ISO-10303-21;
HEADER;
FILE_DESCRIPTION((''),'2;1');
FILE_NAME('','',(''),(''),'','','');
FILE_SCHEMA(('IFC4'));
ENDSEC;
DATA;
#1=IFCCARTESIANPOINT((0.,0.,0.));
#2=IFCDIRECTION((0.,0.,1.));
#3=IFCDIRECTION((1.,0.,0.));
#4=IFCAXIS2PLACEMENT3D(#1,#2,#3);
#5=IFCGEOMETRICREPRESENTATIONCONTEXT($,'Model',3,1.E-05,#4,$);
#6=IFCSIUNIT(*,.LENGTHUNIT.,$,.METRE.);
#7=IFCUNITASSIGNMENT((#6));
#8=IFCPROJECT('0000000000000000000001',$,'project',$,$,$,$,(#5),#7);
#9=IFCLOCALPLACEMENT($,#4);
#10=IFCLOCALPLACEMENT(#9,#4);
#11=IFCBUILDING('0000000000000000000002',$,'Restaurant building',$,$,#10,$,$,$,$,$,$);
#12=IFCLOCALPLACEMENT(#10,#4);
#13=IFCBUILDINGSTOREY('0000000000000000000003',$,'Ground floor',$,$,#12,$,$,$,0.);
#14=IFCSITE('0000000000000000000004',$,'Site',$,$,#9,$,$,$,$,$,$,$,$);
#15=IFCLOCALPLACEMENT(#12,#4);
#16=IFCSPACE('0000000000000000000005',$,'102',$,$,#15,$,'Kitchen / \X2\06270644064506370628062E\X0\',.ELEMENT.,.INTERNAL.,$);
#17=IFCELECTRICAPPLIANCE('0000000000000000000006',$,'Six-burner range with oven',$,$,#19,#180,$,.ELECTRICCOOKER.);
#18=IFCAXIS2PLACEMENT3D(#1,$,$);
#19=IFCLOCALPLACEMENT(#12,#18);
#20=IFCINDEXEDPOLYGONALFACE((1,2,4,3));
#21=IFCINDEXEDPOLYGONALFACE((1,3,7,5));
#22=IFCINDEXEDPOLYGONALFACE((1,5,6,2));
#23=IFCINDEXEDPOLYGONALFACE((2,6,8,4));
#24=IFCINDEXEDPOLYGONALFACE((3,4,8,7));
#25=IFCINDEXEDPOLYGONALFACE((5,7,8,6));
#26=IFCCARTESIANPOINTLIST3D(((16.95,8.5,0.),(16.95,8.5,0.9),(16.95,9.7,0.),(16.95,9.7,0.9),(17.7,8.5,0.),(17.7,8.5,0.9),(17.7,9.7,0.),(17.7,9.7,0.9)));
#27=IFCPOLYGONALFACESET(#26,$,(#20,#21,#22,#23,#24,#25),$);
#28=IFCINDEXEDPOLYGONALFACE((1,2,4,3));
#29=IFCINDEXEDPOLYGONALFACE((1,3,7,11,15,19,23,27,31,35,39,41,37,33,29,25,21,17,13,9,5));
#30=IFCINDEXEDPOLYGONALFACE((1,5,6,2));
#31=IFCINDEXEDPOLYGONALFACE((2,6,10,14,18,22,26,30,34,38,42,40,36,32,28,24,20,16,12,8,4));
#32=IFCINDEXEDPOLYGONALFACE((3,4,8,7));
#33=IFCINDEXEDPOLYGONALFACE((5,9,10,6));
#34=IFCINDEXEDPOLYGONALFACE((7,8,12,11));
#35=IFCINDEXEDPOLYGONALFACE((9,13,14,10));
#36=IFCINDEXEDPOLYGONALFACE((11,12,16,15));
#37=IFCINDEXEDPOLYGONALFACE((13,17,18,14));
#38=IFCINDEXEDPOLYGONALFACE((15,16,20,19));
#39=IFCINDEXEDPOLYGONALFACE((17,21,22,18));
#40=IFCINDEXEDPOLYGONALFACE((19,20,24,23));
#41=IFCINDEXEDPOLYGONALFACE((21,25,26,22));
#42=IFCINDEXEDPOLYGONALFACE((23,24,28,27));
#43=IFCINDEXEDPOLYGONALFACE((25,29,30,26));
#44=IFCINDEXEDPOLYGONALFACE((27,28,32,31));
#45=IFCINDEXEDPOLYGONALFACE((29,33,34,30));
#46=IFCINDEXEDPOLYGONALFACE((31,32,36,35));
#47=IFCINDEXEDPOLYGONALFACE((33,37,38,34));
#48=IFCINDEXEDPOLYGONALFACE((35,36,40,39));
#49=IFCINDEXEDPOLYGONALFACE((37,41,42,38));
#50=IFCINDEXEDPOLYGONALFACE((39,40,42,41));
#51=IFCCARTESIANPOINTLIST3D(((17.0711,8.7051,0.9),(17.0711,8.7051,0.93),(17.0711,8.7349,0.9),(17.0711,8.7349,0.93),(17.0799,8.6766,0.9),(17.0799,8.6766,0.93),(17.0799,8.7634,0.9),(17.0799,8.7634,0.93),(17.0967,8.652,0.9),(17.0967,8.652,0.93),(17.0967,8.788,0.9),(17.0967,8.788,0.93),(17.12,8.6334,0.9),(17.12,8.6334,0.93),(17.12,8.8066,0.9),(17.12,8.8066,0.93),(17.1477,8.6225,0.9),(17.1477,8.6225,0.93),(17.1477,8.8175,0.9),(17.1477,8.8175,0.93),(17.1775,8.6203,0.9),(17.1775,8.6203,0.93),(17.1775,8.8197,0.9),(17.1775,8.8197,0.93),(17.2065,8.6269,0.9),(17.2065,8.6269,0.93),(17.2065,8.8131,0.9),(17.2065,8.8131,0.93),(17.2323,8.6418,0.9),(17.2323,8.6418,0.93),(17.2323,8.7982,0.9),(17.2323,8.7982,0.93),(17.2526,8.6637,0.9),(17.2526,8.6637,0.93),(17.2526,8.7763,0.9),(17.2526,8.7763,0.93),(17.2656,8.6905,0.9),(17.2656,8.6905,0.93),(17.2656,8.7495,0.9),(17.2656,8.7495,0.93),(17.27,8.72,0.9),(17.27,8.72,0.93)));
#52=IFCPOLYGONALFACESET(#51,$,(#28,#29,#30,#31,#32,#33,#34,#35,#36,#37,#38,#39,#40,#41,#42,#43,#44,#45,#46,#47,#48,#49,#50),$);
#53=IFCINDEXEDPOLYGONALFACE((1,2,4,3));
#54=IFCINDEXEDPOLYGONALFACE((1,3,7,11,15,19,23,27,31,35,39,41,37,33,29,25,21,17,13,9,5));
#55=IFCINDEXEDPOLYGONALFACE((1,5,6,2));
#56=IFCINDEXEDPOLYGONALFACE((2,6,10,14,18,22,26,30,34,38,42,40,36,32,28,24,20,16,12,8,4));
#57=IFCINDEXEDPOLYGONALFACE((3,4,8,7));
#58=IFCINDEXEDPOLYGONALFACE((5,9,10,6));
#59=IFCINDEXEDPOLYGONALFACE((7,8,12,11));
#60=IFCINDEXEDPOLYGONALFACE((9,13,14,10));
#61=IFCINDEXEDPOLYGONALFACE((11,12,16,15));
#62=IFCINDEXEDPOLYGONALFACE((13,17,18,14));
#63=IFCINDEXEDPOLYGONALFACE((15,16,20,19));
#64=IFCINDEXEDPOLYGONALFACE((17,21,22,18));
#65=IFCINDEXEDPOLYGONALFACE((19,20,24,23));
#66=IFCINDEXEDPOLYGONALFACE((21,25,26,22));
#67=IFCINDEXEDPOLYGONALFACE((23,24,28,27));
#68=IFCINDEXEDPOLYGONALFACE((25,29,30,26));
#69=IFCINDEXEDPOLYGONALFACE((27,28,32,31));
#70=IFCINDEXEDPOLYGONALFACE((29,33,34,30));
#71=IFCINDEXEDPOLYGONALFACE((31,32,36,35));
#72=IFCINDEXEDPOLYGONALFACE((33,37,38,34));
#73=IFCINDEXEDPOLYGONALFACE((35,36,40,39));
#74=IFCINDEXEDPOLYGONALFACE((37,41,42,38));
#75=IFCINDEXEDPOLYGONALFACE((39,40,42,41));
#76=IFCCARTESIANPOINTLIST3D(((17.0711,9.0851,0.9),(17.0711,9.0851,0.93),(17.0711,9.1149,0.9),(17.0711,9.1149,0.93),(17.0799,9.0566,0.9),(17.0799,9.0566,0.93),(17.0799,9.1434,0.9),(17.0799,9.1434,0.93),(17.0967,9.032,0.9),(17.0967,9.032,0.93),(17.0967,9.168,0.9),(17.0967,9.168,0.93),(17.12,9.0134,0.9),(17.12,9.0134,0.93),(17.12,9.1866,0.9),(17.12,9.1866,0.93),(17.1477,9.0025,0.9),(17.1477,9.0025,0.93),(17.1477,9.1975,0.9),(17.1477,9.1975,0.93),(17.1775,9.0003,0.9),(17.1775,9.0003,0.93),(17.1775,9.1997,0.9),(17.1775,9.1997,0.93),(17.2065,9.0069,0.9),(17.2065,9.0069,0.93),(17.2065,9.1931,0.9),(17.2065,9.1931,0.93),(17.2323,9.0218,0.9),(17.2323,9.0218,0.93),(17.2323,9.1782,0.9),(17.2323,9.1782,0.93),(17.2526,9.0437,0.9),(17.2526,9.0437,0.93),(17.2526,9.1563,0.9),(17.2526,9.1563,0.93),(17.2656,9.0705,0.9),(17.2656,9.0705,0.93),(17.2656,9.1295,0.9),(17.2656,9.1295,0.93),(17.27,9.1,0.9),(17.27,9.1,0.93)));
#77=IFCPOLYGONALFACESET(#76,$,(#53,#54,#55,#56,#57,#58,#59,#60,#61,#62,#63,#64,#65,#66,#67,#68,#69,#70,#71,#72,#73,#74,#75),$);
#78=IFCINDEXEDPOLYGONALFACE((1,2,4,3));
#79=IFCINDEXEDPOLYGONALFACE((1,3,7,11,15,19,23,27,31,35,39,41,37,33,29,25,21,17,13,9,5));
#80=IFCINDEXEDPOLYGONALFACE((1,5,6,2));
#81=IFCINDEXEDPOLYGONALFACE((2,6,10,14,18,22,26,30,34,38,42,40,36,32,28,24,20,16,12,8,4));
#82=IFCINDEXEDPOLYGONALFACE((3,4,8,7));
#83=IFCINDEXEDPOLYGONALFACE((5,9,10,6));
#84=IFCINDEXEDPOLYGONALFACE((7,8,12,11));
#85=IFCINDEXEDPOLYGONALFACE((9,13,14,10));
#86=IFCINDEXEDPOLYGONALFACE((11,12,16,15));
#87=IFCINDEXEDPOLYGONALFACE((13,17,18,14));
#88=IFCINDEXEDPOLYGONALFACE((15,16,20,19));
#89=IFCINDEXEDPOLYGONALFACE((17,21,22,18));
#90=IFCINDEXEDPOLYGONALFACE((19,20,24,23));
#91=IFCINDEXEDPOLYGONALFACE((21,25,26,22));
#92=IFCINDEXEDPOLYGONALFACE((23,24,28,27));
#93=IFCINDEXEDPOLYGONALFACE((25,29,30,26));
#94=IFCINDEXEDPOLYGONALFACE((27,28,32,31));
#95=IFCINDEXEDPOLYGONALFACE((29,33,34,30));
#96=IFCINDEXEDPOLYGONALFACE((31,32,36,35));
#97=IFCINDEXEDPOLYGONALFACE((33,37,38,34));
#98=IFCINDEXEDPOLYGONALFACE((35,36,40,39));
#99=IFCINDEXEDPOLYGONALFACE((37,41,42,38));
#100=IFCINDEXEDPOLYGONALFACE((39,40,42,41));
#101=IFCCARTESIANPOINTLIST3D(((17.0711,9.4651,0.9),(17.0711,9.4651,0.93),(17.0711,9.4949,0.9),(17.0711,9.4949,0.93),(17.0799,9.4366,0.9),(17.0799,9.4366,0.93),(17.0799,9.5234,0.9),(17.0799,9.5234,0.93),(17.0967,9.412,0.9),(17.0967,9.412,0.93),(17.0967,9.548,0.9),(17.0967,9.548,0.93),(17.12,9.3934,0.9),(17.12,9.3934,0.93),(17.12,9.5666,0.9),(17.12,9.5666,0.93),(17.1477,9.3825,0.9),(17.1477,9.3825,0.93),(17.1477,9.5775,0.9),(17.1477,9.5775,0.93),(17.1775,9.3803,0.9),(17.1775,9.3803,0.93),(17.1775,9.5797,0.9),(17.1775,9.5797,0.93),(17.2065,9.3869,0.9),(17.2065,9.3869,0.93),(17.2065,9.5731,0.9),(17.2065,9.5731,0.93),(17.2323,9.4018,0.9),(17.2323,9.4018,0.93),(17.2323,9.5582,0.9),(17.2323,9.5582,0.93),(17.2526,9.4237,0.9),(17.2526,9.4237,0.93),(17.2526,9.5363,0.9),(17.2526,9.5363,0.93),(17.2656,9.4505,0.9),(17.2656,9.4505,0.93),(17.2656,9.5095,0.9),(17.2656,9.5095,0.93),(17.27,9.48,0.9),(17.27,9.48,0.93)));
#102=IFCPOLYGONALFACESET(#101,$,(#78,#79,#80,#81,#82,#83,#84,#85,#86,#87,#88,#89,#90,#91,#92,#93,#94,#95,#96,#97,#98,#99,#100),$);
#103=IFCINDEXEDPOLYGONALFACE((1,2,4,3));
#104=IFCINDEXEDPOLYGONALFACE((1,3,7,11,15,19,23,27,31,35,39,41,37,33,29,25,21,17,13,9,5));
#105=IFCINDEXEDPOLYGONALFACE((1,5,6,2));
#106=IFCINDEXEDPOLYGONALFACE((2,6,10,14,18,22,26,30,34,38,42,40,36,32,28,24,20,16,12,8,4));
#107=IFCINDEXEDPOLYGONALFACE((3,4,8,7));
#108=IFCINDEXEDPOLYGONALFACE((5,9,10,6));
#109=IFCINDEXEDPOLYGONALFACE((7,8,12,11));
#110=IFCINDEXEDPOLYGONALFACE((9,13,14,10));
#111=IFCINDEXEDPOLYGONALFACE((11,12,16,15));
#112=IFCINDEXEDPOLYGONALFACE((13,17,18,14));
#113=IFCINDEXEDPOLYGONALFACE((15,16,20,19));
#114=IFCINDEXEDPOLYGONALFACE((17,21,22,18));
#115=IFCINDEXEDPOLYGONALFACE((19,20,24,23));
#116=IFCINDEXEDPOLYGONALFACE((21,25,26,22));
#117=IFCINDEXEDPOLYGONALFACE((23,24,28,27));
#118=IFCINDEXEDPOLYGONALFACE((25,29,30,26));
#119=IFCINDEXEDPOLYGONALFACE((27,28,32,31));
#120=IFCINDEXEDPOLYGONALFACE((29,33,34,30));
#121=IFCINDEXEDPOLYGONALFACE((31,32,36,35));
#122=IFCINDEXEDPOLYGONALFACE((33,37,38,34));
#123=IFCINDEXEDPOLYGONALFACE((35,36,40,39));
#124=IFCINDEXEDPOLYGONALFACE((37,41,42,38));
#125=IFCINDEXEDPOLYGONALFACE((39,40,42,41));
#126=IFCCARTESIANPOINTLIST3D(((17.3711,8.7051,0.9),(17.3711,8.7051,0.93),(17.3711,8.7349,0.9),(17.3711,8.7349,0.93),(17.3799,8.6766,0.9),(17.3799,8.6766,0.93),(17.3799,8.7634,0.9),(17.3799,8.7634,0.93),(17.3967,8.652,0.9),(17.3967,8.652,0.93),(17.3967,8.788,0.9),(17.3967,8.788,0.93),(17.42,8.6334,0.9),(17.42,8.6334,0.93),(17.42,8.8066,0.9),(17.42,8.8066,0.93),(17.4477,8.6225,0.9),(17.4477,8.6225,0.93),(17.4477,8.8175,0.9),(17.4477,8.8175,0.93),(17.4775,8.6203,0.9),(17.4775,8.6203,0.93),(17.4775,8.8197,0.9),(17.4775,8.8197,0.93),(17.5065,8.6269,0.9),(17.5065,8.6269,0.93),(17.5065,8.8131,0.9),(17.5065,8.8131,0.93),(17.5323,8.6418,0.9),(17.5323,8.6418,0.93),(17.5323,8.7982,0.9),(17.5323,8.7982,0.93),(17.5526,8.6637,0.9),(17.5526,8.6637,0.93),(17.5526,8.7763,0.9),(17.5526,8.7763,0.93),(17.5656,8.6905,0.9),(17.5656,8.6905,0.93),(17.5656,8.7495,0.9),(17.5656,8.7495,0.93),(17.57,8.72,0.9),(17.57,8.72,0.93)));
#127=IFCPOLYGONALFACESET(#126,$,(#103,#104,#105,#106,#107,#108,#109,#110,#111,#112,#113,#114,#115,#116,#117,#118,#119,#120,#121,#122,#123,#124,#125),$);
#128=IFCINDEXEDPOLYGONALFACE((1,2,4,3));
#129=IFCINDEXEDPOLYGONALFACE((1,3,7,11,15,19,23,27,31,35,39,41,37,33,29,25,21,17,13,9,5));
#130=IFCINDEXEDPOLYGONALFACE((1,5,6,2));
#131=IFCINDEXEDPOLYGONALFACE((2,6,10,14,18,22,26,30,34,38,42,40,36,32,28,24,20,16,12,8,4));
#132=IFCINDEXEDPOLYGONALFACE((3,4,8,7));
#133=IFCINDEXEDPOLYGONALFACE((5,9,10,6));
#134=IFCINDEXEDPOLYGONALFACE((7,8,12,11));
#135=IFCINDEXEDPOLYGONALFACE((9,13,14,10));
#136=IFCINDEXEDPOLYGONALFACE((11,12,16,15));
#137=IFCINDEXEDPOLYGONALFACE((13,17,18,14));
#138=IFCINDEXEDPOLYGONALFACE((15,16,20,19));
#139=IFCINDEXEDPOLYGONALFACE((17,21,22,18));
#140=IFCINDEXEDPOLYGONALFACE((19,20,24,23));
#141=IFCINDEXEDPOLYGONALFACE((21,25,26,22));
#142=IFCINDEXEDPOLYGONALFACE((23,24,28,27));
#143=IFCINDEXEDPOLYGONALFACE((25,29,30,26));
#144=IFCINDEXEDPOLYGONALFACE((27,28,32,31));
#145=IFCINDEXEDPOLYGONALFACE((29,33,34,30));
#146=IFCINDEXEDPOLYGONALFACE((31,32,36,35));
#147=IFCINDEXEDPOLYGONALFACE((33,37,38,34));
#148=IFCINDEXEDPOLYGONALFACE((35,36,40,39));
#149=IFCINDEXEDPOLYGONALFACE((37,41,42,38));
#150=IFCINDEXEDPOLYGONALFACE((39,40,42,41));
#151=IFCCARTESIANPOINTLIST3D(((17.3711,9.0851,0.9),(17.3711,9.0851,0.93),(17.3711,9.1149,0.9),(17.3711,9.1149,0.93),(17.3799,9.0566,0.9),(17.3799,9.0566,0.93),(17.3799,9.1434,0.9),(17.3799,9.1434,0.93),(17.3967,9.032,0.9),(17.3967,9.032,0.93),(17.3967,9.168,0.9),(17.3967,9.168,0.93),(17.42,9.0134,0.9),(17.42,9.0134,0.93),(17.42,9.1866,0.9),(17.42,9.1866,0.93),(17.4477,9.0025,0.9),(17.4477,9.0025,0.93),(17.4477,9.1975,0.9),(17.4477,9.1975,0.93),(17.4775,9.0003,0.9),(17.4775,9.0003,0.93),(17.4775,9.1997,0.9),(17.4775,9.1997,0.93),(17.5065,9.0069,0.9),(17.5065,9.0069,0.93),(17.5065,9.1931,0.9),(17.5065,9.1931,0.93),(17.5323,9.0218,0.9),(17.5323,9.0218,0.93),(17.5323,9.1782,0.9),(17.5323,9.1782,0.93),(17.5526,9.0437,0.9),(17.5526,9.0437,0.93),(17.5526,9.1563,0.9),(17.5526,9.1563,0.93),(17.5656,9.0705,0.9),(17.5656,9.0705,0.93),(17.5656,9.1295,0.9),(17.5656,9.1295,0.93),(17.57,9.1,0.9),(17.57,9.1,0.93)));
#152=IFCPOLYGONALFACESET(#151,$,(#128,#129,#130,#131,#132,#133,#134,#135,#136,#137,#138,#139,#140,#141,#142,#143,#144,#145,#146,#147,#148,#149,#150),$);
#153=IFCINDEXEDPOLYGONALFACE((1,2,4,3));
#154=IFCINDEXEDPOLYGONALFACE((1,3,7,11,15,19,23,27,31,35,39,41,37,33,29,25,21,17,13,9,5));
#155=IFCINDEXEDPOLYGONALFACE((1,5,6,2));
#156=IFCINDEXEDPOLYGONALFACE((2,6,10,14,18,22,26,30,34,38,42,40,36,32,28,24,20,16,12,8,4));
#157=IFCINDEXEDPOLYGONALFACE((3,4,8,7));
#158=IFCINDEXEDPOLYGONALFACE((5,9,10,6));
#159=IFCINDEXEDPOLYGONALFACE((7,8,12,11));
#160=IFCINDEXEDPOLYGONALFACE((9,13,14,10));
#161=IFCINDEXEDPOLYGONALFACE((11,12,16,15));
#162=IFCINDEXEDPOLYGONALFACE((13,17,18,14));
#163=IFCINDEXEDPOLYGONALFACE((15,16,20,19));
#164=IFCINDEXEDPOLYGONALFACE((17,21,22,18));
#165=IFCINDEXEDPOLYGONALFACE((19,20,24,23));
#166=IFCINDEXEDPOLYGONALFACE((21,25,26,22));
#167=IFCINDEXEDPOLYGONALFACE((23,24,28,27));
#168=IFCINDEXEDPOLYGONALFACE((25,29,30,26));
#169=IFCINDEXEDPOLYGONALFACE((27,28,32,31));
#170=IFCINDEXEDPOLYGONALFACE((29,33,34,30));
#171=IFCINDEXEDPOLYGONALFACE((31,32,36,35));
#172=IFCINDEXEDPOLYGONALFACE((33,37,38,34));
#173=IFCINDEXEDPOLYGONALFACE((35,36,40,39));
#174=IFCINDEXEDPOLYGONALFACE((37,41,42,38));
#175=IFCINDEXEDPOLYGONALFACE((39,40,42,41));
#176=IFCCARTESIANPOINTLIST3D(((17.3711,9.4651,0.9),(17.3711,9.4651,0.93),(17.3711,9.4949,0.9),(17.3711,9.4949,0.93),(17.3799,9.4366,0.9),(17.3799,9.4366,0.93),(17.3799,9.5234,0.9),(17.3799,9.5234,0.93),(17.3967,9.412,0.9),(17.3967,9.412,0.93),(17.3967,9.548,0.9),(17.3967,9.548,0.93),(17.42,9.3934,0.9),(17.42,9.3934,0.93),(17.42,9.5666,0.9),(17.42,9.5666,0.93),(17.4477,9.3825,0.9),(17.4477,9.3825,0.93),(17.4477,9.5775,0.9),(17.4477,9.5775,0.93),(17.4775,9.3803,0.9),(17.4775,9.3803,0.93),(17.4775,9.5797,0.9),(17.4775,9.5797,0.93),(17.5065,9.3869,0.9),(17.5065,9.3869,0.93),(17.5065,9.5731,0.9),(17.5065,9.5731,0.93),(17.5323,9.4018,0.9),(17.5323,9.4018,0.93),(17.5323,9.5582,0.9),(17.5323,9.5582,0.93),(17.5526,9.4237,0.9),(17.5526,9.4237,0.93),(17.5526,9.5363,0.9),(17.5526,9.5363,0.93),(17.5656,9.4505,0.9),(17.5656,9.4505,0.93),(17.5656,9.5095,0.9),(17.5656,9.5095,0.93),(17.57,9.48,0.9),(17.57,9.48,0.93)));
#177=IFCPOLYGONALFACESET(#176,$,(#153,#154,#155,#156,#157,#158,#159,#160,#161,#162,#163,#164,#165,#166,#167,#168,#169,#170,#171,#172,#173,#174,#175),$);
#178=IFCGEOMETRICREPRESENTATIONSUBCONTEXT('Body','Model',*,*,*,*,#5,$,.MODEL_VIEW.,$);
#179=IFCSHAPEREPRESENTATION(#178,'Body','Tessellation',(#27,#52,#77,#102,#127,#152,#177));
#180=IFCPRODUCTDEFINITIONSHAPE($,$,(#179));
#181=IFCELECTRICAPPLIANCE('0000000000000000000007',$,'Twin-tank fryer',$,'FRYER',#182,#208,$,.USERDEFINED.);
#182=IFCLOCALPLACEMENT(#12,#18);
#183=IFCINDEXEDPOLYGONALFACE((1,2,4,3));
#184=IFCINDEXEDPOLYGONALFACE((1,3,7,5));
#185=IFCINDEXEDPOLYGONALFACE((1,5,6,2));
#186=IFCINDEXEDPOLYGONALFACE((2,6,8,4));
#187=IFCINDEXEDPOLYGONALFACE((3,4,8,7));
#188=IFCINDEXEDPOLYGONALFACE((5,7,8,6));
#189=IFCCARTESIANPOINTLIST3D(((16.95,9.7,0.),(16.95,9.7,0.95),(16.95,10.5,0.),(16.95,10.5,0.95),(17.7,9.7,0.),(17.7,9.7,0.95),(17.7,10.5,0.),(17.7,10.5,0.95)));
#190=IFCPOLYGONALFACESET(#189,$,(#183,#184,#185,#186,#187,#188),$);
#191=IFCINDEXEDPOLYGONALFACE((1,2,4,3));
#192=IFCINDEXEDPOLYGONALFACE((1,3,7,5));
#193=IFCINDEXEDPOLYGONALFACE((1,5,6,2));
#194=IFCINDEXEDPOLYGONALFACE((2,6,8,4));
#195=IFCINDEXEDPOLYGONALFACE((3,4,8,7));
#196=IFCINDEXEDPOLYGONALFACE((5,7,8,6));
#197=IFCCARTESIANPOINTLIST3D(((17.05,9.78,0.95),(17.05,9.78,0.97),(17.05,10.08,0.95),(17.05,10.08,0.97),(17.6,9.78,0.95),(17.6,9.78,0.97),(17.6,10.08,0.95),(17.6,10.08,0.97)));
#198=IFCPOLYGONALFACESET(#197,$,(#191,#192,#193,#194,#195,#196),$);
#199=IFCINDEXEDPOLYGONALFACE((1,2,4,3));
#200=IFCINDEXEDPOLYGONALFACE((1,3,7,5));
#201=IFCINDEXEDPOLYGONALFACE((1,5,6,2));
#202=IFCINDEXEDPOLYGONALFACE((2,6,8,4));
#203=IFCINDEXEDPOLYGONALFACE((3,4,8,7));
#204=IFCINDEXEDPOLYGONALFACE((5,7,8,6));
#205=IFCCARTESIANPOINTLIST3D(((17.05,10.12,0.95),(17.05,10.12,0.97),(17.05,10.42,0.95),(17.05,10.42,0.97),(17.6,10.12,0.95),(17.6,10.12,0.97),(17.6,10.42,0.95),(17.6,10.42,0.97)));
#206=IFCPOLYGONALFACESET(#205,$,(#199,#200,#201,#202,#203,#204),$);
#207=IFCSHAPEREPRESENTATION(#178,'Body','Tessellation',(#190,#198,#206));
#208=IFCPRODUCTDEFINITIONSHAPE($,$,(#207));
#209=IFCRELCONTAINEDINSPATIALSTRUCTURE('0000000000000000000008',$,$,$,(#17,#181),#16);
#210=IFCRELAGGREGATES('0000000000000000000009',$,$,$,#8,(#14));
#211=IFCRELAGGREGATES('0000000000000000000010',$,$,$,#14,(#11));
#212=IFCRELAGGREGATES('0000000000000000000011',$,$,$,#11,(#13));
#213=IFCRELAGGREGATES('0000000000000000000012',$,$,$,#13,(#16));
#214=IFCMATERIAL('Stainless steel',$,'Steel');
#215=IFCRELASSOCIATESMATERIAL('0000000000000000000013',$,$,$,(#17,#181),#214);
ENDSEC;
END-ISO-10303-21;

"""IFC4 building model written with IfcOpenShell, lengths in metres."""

from ifc_helpers import new_model, si_unit, frame, origin_with_axes, origin_2d, place, context, subcontext, project, spatial, rectangle, circle, extrude, material, element, save


model = new_model("IFC4")

# Units and contexts
model_context = context("Model", 3, precision=1e-05, world=origin_with_axes())
body_context = subcontext(model_context, "Body", "Model", "MODEL_VIEW")
ifc_project = project(units=[si_unit("LENGTHUNIT", "METRE")], contexts=[model_context])

# Site, building, storey, space
site_placement = place(None, origin_with_axes())
site = spatial("IfcSite", under=ifc_project, at=site_placement, Name="Site")
building_placement = place(site_placement, origin_with_axes())
building = spatial("IfcBuilding", under=site, at=building_placement, Name="Restaurant building")
storey_placement = place(building_placement, origin_with_axes())
storey = spatial("IfcBuildingStorey", under=building, at=storey_placement, Name="Ground floor", Elevation=0.0)
space_placement = place(storey_placement, origin_with_axes())
space = spatial("IfcSpace", under=storey, at=space_placement, Name="102", LongName="Kitchen / المطبخ", CompositionType="ELEMENT", PredefinedType="INTERNAL")

# Electric appliances
ifc_material_1 = material(Name="Stainless steel", Category="Steel")
electric_appliance_1_placement = place(storey_placement, frame((16.95, 8.5, 0.0)))
element("IfcElectricAppliance", 1, at=electric_appliance_1_placement, inside=space, material=ifc_material_1, Name="Six-burner range with oven", PredefinedType="ELECTRICCOOKER", context=body_context, shape_type="SweptSolid", body=[
    extrude(rectangle(XDim=0.75, YDim=1.2, at=origin_2d()), frame((0.375, 0.6, 0.0)), (0.0, 0.0, 1.0), 0.9),
    extrude(circle(Radius=0.1, at=origin_2d()), frame((0.22, 0.22, 0.9)), (0.0, 0.0, 1.0), 0.03),
    extrude(circle(Radius=0.1, at=origin_2d()), frame((0.22, 0.6, 0.9)), (0.0, 0.0, 1.0), 0.03),
    extrude(circle(Radius=0.1, at=origin_2d()), frame((0.22, 0.98, 0.9)), (0.0, 0.0, 1.0), 0.03),
    extrude(circle(Radius=0.1, at=origin_2d()), frame((0.52, 0.22, 0.9)), (0.0, 0.0, 1.0), 0.03),
    extrude(circle(Radius=0.1, at=origin_2d()), frame((0.52, 0.6, 0.9)), (0.0, 0.0, 1.0), 0.03),
    extrude(circle(Radius=0.1, at=origin_2d()), frame((0.52, 0.98, 0.9)), (0.0, 0.0, 1.0), 0.03),
])
electric_appliance_2_placement = place(storey_placement, frame((16.95, 9.7, 0.0)))
element("IfcElectricAppliance", 2, at=electric_appliance_2_placement, inside=space, material=ifc_material_1, Name="Twin-tank fryer", ObjectType="FRYER", PredefinedType="USERDEFINED", context=body_context, shape_type="SweptSolid", body=[
    extrude(rectangle(XDim=0.75, YDim=0.8, at=origin_2d()), frame((0.375, 0.4, 0.0)), (0.0, 0.0, 1.0), 0.95),
    extrude(rectangle(XDim=0.55, YDim=0.3, at=origin_2d()), frame((0.375, 0.23, 0.95)), (0.0, 0.0, 1.0), 0.02),
    extrude(rectangle(XDim=0.55, YDim=0.3, at=origin_2d()), frame((0.375, 0.57, 0.95)), (0.0, 0.0, 1.0), 0.02),
])

save(model, "model.ifc")
